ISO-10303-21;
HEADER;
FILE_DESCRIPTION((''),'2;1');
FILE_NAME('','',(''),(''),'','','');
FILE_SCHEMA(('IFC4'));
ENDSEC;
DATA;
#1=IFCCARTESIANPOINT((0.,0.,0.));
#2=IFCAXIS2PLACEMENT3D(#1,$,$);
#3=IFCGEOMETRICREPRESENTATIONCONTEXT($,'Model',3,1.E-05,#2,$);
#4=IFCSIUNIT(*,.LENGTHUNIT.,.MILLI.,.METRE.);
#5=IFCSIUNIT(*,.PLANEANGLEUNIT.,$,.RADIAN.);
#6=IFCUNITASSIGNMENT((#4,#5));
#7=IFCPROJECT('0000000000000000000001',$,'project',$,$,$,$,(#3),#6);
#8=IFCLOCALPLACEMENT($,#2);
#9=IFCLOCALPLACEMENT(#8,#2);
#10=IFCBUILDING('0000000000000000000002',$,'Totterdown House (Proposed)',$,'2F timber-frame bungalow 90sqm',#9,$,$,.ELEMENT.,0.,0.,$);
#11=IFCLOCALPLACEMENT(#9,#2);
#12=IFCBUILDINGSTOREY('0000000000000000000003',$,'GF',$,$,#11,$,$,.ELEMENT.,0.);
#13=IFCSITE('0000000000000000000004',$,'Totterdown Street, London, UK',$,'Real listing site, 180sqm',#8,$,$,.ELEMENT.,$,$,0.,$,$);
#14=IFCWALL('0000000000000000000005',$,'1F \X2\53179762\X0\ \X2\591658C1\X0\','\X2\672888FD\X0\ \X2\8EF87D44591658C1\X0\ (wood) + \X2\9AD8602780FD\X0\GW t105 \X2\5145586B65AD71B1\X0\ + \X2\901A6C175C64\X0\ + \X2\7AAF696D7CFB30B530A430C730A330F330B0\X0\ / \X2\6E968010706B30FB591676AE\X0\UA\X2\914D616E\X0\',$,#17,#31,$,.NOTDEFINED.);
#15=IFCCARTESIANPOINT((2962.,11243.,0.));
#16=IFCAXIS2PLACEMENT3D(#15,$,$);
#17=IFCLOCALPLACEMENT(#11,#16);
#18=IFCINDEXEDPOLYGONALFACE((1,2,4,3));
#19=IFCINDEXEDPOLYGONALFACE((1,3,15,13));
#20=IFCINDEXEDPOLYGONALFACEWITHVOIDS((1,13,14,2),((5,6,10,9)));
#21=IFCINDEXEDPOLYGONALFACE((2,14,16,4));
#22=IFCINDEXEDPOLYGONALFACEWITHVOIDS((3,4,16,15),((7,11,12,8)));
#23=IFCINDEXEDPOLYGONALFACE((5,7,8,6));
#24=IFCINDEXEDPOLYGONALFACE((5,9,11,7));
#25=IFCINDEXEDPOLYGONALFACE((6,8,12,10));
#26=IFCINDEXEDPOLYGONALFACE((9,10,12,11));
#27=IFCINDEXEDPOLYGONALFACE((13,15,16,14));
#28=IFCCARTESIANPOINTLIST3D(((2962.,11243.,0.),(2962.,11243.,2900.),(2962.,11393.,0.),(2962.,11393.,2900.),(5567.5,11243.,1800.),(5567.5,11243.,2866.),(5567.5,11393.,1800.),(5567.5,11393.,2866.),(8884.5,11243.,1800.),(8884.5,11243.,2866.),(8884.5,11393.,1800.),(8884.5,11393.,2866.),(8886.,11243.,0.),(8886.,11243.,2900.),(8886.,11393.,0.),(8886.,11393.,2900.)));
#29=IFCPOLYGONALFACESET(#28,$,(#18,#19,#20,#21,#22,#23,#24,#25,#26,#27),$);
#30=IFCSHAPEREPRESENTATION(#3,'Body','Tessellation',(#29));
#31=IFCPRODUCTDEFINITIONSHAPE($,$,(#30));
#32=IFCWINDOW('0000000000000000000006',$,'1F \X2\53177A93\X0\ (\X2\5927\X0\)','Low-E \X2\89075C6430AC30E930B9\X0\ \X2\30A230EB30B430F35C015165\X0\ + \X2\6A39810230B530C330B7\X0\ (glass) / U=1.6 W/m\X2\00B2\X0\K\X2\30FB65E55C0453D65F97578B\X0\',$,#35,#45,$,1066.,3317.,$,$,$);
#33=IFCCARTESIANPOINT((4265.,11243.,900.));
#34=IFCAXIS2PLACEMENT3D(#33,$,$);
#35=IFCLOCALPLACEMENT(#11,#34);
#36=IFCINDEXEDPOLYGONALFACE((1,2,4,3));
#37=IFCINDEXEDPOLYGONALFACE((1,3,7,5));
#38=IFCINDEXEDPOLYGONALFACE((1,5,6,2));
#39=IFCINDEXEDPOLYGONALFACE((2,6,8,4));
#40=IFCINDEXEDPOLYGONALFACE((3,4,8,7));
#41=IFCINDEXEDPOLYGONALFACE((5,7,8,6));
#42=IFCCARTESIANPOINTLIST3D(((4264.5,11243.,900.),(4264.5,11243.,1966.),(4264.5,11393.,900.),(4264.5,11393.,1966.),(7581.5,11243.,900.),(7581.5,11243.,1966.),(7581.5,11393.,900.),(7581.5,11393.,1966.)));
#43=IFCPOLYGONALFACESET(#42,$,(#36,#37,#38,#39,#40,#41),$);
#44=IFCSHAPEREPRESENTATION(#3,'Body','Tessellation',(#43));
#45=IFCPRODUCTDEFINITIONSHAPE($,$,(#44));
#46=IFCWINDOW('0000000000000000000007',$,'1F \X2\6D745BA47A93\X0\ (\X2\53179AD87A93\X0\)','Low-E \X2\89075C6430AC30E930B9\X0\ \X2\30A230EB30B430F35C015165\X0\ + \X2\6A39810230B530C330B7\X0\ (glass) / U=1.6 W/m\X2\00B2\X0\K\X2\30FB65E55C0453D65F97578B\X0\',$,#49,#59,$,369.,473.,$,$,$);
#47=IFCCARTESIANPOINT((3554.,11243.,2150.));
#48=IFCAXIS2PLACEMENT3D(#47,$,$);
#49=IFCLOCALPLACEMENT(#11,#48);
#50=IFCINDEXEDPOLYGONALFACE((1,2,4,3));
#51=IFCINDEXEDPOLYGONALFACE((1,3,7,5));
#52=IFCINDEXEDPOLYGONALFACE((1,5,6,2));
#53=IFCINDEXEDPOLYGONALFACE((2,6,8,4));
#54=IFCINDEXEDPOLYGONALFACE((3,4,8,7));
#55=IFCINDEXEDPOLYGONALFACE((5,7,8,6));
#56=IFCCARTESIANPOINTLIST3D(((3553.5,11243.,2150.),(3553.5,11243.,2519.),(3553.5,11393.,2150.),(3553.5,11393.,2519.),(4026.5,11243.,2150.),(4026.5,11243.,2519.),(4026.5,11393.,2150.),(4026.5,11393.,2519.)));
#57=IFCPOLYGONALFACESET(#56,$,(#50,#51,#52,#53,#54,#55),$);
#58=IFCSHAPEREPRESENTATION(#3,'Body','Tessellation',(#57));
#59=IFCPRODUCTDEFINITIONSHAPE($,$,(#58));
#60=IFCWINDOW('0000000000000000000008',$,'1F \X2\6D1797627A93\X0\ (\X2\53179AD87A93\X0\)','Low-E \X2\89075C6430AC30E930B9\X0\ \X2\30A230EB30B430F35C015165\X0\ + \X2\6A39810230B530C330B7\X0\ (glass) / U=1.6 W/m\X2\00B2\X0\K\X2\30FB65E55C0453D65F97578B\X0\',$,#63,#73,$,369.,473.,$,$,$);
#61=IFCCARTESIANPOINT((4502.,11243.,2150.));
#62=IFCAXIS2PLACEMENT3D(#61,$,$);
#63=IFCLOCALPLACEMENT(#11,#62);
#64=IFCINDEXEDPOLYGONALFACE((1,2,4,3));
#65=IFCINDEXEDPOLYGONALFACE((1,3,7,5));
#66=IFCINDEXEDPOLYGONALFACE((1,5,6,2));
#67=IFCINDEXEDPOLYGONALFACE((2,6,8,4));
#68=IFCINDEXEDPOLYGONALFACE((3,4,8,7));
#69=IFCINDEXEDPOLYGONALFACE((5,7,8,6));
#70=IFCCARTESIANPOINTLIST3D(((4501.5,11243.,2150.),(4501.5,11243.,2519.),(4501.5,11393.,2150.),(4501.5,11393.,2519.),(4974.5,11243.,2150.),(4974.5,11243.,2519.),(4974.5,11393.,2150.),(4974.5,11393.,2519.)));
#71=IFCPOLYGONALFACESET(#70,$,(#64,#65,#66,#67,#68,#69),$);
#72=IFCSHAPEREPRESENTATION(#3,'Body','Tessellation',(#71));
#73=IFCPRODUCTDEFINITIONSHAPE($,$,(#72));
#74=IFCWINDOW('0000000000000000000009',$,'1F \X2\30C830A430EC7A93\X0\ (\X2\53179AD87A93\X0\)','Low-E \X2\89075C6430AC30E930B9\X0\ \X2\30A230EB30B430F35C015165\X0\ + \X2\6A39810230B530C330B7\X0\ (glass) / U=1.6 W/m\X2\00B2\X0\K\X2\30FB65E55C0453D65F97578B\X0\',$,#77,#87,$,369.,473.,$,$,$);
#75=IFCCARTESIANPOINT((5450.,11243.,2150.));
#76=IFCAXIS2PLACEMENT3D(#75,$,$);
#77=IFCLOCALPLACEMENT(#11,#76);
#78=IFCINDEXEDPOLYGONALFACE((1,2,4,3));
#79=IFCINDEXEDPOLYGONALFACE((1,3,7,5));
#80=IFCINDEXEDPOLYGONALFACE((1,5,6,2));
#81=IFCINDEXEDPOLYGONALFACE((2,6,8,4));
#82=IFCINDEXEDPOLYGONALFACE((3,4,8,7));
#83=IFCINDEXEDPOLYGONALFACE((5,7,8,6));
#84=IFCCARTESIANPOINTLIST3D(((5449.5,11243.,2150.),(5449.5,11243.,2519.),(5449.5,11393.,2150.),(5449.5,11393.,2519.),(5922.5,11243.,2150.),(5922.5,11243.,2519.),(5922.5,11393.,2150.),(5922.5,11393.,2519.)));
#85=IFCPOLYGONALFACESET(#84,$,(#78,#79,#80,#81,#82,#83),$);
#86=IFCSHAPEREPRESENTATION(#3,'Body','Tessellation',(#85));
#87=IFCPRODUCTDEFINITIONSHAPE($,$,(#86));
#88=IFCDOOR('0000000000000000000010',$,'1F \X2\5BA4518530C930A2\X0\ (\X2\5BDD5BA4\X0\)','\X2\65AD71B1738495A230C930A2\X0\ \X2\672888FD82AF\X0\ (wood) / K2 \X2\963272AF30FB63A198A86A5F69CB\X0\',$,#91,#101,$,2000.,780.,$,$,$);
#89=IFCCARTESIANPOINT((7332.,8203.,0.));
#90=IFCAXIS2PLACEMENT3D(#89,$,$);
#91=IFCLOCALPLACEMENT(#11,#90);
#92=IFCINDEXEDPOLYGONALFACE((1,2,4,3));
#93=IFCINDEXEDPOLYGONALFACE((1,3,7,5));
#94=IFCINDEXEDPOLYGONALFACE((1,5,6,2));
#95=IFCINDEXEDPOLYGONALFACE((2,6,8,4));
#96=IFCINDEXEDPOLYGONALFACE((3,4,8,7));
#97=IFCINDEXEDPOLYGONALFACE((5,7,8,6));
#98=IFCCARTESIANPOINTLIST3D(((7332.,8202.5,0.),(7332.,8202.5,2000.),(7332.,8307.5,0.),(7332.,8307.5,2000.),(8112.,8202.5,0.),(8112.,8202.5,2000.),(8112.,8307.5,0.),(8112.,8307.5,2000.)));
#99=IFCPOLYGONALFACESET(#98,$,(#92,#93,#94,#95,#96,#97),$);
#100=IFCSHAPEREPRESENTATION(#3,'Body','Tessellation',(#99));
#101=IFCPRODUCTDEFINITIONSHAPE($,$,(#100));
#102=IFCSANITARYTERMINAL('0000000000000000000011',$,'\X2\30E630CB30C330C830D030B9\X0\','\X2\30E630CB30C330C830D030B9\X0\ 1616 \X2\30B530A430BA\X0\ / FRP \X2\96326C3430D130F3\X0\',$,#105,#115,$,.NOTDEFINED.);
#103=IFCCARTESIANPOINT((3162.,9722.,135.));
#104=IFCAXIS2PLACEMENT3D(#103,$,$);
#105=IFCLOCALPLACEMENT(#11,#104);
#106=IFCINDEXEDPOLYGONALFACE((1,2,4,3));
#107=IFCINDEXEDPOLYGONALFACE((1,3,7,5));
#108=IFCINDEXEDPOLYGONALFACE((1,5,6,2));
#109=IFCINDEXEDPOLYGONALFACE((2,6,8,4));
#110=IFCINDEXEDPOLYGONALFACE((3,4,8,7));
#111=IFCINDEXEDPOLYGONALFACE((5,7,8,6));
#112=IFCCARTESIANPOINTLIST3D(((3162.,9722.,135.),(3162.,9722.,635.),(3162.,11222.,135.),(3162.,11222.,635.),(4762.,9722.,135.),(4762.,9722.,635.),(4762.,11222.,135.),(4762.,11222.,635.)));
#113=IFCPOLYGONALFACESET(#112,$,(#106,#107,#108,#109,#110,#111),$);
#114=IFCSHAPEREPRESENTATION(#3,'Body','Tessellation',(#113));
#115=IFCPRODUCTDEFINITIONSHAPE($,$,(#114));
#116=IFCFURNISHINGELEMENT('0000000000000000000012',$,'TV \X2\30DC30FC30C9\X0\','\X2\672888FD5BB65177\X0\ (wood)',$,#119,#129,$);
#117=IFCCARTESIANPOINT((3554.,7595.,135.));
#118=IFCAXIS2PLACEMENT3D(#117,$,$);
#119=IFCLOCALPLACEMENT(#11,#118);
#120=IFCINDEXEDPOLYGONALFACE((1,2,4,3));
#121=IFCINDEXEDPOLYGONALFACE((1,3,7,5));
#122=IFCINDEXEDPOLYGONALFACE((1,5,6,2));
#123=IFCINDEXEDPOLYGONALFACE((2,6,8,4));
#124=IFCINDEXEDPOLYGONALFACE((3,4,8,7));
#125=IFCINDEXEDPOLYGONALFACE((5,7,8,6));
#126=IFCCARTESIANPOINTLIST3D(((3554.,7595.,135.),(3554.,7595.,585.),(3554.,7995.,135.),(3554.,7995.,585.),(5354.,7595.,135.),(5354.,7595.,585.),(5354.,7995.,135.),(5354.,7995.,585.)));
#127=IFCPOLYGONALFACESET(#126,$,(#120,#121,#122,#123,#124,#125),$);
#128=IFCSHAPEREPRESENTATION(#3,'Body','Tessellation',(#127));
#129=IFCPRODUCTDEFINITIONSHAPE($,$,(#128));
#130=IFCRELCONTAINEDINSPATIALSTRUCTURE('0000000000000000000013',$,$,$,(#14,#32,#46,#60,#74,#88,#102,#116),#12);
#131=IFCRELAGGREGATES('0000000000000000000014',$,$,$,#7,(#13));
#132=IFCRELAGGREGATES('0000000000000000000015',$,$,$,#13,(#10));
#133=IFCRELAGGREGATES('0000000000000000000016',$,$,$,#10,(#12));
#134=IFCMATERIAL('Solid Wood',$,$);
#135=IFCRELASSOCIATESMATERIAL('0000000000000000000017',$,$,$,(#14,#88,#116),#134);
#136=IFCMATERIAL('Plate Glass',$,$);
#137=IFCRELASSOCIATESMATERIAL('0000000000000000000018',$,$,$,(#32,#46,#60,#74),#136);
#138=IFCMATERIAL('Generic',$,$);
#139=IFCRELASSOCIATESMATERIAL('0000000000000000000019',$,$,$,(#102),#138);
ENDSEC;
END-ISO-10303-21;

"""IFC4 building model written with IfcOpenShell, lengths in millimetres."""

from ifc_helpers import new_model, si_unit, frame, frame_2d, origin, place, context, project, spatial, rectangle, extrude, material, element, fill, save


model = new_model("IFC4")

# Units and contexts
model_context = context("Model", 3, precision=1e-05, world=origin())
ifc_project = project(units=[si_unit("LENGTHUNIT", "METRE", prefix="MILLI"), si_unit("PLANEANGLEUNIT", "RADIAN")], contexts=[model_context])

# Site, building, storey
site_placement = place(None, origin())
site = spatial("IfcSite", under=ifc_project, at=site_placement, Name="Totterdown Street, London, UK", ObjectType="Real listing site, 180sqm", CompositionType="ELEMENT", RefElevation=0.0)
building_placement = place(site_placement, origin())
building = spatial("IfcBuilding", under=site, at=building_placement, Name="Totterdown House (Proposed)", ObjectType="2F timber-frame bungalow 90sqm", CompositionType="ELEMENT", ElevationOfRefHeight=0.0, ElevationOfTerrain=0.0)
storey_placement = place(building_placement, origin())
storey = spatial("IfcBuildingStorey", under=building, at=storey_placement, Name="GF", CompositionType="ELEMENT", Elevation=0.0)

# Wall, openings, windows
ifc_material_1 = material(Name="Solid Wood")
wall_1_placement = place(storey_placement, frame((2962.0, 11243.0, 0.0)))
wall_1 = element("IfcWall", 1, at=wall_1_placement, inside=storey, material=ifc_material_1, Name="1F 北面 外壁", Description="木製 軸組外壁 (wood) + 高性能GW t105 充填断熱 + 通気層 + 窯業系サイディング / 準耐火・外皮UA配慮", PredefinedType="NOTDEFINED", context=model_context, shape_type="SweptSolid", body=[
    extrude(rectangle(XDim=5924.0, YDim=150.0, at=frame_2d((2962.0, 75.0))), frame((2962.0, 11243.0, 0.0)), (0.0, 0.0, 1.0), 2900.0),
])
opening_1_placement = place(storey_placement, frame((4265.0, 11243.0, 900.0)))
opening_1 = element("IfcOpeningElement", 2, at=opening_1_placement, cuts=wall_1, PredefinedType="NOTDEFINED", context=model_context, shape_type="SweptSolid", body=[
    extrude(rectangle(XDim=3317.0, YDim=150.0, at=frame_2d((1658.0, 75.0))), frame((4265.0, 11243.0, 900.0)), (0.0, 0.0, 1.0), 1066.0),
])
opening_2_placement = place(storey_placement, frame((3554.0, 11243.0, 2150.0)))
opening_2 = element("IfcOpeningElement", 3, at=opening_2_placement, cuts=wall_1, PredefinedType="NOTDEFINED", context=model_context, shape_type="SweptSolid", body=[
    extrude(rectangle(XDim=473.0, YDim=150.0, at=frame_2d((236.0, 75.0))), frame((3554.0, 11243.0, 2150.0)), (0.0, 0.0, 1.0), 369.0),
])
opening_3_placement = place(storey_placement, frame((4502.0, 11243.0, 2150.0)))
opening_3 = element("IfcOpeningElement", 4, at=opening_3_placement, cuts=wall_1, PredefinedType="NOTDEFINED", context=model_context, shape_type="SweptSolid", body=[
    extrude(rectangle(XDim=473.0, YDim=150.0, at=frame_2d((236.0, 75.0))), frame((4502.0, 11243.0, 2150.0)), (0.0, 0.0, 1.0), 369.0),
])
opening_4_placement = place(storey_placement, frame((5450.0, 11243.0, 2150.0)))
opening_4 = element("IfcOpeningElement", 5, at=opening_4_placement, cuts=wall_1, PredefinedType="NOTDEFINED", context=model_context, shape_type="SweptSolid", body=[
    extrude(rectangle(XDim=473.0, YDim=150.0, at=frame_2d((236.0, 75.0))), frame((5450.0, 11243.0, 2150.0)), (0.0, 0.0, 1.0), 369.0),
])
ifc_material_2 = material(Name="Plate Glass")
window_1_placement = place(storey_placement, frame((4265.0, 11243.0, 900.0)))
window_1 = element("IfcWindow", 6, at=window_1_placement, inside=storey, material=ifc_material_2, Name="1F 北窓 (大)", Description="Low-E 複層ガラス アルゴン封入 + 樹脂サッシ (glass) / U=1.6 W/m²K・日射取得型", OverallHeight=1066.0, OverallWidth=3317.0, context=model_context, shape_type="SweptSolid", body=[
    extrude(rectangle(XDim=3317.0, YDim=150.0, at=frame_2d((1658.0, 75.0))), frame((4265.0, 11243.0, 900.0)), (0.0, 0.0, 1.0), 1066.0),
])
fill(opening_1, window_1)
window_2_placement = place(storey_placement, frame((3554.0, 11243.0, 2150.0)))
window_2 = element("IfcWindow", 7, at=window_2_placement, inside=storey, material=ifc_material_2, Name="1F 浴室窓 (北高窓)", Description="Low-E 複層ガラス アルゴン封入 + 樹脂サッシ (glass) / U=1.6 W/m²K・日射取得型", OverallHeight=369.0, OverallWidth=473.0, context=model_context, shape_type="SweptSolid", body=[
    extrude(rectangle(XDim=473.0, YDim=150.0, at=frame_2d((236.0, 75.0))), frame((3554.0, 11243.0, 2150.0)), (0.0, 0.0, 1.0), 369.0),
])
fill(opening_2, window_2)
window_3_placement = place(storey_placement, frame((4502.0, 11243.0, 2150.0)))
window_3 = element("IfcWindow", 8, at=window_3_placement, inside=storey, material=ifc_material_2, Name="1F 洗面窓 (北高窓)", Description="Low-E 複層ガラス アルゴン封入 + 樹脂サッシ (glass) / U=1.6 W/m²K・日射取得型", OverallHeight=369.0, OverallWidth=473.0, context=model_context, shape_type="SweptSolid", body=[
    extrude(rectangle(XDim=473.0, YDim=150.0, at=frame_2d((236.0, 75.0))), frame((4502.0, 11243.0, 2150.0)), (0.0, 0.0, 1.0), 369.0),
])
fill(opening_3, window_3)
window_4_placement = place(storey_placement, frame((5450.0, 11243.0, 2150.0)))
window_4 = element("IfcWindow", 9, at=window_4_placement, inside=storey, material=ifc_material_2, Name="1F トイレ窓 (北高窓)", Description="Low-E 複層ガラス アルゴン封入 + 樹脂サッシ (glass) / U=1.6 W/m²K・日射取得型", OverallHeight=369.0, OverallWidth=473.0, context=model_context, shape_type="SweptSolid", body=[
    extrude(rectangle(XDim=473.0, YDim=150.0, at=frame_2d((236.0, 75.0))), frame((5450.0, 11243.0, 2150.0)), (0.0, 0.0, 1.0), 369.0),
])
fill(opening_4, window_4)

# Door
door_1_placement = place(storey_placement, frame((7332.0, 8203.0, 0.0)))
element("IfcDoor", 10, at=door_1_placement, inside=storey, material=ifc_material_1, Name="1F 室内ドア (寝室)", Description="断熱玄関ドア 木製芯 (wood) / K2 防犯・採風機構", OverallHeight=2000.0, OverallWidth=780.0, context=model_context, shape_type="SweptSolid", body=[
    extrude(rectangle(XDim=780.0, YDim=105.0, at=frame_2d((390.0, 52.0))), frame((7332.0, 8203.0, 0.0)), (0.0, 0.0, 1.0), 2000.0),
])

# Sanitary terminal
ifc_material_3 = material(Name="Generic")
sanitary_terminal_placement = place(storey_placement, frame((3162.0, 9722.0, 135.0)))
element("IfcSanitaryTerminal", 11, at=sanitary_terminal_placement, inside=storey, material=ifc_material_3, Name="ユニットバス", Description="ユニットバス 1616 サイズ / FRP 防水パン", PredefinedType="NOTDEFINED", context=model_context, shape_type="SweptSolid", body=[
    extrude(rectangle(XDim=1600.0, YDim=1500.0, at=frame_2d((800.0, 750.0))), frame((3162.0, 9722.0, 135.0)), (0.0, 0.0, 1.0), 500.0),
])

# Furnishing element
furnishing_placement = place(storey_placement, frame((3554.0, 7595.0, 135.0)))
element("IfcFurnishingElement", 12, at=furnishing_placement, inside=storey, material=ifc_material_1, Name="TV ボード", Description="木製家具 (wood)", context=model_context, shape_type="SweptSolid", body=[
    extrude(rectangle(XDim=1800.0, YDim=400.0, at=frame_2d((900.0, 200.0))), frame((3554.0, 7595.0, 135.0)), (0.0, 0.0, 1.0), 450.0),
])

save(model, "model.ifc")
